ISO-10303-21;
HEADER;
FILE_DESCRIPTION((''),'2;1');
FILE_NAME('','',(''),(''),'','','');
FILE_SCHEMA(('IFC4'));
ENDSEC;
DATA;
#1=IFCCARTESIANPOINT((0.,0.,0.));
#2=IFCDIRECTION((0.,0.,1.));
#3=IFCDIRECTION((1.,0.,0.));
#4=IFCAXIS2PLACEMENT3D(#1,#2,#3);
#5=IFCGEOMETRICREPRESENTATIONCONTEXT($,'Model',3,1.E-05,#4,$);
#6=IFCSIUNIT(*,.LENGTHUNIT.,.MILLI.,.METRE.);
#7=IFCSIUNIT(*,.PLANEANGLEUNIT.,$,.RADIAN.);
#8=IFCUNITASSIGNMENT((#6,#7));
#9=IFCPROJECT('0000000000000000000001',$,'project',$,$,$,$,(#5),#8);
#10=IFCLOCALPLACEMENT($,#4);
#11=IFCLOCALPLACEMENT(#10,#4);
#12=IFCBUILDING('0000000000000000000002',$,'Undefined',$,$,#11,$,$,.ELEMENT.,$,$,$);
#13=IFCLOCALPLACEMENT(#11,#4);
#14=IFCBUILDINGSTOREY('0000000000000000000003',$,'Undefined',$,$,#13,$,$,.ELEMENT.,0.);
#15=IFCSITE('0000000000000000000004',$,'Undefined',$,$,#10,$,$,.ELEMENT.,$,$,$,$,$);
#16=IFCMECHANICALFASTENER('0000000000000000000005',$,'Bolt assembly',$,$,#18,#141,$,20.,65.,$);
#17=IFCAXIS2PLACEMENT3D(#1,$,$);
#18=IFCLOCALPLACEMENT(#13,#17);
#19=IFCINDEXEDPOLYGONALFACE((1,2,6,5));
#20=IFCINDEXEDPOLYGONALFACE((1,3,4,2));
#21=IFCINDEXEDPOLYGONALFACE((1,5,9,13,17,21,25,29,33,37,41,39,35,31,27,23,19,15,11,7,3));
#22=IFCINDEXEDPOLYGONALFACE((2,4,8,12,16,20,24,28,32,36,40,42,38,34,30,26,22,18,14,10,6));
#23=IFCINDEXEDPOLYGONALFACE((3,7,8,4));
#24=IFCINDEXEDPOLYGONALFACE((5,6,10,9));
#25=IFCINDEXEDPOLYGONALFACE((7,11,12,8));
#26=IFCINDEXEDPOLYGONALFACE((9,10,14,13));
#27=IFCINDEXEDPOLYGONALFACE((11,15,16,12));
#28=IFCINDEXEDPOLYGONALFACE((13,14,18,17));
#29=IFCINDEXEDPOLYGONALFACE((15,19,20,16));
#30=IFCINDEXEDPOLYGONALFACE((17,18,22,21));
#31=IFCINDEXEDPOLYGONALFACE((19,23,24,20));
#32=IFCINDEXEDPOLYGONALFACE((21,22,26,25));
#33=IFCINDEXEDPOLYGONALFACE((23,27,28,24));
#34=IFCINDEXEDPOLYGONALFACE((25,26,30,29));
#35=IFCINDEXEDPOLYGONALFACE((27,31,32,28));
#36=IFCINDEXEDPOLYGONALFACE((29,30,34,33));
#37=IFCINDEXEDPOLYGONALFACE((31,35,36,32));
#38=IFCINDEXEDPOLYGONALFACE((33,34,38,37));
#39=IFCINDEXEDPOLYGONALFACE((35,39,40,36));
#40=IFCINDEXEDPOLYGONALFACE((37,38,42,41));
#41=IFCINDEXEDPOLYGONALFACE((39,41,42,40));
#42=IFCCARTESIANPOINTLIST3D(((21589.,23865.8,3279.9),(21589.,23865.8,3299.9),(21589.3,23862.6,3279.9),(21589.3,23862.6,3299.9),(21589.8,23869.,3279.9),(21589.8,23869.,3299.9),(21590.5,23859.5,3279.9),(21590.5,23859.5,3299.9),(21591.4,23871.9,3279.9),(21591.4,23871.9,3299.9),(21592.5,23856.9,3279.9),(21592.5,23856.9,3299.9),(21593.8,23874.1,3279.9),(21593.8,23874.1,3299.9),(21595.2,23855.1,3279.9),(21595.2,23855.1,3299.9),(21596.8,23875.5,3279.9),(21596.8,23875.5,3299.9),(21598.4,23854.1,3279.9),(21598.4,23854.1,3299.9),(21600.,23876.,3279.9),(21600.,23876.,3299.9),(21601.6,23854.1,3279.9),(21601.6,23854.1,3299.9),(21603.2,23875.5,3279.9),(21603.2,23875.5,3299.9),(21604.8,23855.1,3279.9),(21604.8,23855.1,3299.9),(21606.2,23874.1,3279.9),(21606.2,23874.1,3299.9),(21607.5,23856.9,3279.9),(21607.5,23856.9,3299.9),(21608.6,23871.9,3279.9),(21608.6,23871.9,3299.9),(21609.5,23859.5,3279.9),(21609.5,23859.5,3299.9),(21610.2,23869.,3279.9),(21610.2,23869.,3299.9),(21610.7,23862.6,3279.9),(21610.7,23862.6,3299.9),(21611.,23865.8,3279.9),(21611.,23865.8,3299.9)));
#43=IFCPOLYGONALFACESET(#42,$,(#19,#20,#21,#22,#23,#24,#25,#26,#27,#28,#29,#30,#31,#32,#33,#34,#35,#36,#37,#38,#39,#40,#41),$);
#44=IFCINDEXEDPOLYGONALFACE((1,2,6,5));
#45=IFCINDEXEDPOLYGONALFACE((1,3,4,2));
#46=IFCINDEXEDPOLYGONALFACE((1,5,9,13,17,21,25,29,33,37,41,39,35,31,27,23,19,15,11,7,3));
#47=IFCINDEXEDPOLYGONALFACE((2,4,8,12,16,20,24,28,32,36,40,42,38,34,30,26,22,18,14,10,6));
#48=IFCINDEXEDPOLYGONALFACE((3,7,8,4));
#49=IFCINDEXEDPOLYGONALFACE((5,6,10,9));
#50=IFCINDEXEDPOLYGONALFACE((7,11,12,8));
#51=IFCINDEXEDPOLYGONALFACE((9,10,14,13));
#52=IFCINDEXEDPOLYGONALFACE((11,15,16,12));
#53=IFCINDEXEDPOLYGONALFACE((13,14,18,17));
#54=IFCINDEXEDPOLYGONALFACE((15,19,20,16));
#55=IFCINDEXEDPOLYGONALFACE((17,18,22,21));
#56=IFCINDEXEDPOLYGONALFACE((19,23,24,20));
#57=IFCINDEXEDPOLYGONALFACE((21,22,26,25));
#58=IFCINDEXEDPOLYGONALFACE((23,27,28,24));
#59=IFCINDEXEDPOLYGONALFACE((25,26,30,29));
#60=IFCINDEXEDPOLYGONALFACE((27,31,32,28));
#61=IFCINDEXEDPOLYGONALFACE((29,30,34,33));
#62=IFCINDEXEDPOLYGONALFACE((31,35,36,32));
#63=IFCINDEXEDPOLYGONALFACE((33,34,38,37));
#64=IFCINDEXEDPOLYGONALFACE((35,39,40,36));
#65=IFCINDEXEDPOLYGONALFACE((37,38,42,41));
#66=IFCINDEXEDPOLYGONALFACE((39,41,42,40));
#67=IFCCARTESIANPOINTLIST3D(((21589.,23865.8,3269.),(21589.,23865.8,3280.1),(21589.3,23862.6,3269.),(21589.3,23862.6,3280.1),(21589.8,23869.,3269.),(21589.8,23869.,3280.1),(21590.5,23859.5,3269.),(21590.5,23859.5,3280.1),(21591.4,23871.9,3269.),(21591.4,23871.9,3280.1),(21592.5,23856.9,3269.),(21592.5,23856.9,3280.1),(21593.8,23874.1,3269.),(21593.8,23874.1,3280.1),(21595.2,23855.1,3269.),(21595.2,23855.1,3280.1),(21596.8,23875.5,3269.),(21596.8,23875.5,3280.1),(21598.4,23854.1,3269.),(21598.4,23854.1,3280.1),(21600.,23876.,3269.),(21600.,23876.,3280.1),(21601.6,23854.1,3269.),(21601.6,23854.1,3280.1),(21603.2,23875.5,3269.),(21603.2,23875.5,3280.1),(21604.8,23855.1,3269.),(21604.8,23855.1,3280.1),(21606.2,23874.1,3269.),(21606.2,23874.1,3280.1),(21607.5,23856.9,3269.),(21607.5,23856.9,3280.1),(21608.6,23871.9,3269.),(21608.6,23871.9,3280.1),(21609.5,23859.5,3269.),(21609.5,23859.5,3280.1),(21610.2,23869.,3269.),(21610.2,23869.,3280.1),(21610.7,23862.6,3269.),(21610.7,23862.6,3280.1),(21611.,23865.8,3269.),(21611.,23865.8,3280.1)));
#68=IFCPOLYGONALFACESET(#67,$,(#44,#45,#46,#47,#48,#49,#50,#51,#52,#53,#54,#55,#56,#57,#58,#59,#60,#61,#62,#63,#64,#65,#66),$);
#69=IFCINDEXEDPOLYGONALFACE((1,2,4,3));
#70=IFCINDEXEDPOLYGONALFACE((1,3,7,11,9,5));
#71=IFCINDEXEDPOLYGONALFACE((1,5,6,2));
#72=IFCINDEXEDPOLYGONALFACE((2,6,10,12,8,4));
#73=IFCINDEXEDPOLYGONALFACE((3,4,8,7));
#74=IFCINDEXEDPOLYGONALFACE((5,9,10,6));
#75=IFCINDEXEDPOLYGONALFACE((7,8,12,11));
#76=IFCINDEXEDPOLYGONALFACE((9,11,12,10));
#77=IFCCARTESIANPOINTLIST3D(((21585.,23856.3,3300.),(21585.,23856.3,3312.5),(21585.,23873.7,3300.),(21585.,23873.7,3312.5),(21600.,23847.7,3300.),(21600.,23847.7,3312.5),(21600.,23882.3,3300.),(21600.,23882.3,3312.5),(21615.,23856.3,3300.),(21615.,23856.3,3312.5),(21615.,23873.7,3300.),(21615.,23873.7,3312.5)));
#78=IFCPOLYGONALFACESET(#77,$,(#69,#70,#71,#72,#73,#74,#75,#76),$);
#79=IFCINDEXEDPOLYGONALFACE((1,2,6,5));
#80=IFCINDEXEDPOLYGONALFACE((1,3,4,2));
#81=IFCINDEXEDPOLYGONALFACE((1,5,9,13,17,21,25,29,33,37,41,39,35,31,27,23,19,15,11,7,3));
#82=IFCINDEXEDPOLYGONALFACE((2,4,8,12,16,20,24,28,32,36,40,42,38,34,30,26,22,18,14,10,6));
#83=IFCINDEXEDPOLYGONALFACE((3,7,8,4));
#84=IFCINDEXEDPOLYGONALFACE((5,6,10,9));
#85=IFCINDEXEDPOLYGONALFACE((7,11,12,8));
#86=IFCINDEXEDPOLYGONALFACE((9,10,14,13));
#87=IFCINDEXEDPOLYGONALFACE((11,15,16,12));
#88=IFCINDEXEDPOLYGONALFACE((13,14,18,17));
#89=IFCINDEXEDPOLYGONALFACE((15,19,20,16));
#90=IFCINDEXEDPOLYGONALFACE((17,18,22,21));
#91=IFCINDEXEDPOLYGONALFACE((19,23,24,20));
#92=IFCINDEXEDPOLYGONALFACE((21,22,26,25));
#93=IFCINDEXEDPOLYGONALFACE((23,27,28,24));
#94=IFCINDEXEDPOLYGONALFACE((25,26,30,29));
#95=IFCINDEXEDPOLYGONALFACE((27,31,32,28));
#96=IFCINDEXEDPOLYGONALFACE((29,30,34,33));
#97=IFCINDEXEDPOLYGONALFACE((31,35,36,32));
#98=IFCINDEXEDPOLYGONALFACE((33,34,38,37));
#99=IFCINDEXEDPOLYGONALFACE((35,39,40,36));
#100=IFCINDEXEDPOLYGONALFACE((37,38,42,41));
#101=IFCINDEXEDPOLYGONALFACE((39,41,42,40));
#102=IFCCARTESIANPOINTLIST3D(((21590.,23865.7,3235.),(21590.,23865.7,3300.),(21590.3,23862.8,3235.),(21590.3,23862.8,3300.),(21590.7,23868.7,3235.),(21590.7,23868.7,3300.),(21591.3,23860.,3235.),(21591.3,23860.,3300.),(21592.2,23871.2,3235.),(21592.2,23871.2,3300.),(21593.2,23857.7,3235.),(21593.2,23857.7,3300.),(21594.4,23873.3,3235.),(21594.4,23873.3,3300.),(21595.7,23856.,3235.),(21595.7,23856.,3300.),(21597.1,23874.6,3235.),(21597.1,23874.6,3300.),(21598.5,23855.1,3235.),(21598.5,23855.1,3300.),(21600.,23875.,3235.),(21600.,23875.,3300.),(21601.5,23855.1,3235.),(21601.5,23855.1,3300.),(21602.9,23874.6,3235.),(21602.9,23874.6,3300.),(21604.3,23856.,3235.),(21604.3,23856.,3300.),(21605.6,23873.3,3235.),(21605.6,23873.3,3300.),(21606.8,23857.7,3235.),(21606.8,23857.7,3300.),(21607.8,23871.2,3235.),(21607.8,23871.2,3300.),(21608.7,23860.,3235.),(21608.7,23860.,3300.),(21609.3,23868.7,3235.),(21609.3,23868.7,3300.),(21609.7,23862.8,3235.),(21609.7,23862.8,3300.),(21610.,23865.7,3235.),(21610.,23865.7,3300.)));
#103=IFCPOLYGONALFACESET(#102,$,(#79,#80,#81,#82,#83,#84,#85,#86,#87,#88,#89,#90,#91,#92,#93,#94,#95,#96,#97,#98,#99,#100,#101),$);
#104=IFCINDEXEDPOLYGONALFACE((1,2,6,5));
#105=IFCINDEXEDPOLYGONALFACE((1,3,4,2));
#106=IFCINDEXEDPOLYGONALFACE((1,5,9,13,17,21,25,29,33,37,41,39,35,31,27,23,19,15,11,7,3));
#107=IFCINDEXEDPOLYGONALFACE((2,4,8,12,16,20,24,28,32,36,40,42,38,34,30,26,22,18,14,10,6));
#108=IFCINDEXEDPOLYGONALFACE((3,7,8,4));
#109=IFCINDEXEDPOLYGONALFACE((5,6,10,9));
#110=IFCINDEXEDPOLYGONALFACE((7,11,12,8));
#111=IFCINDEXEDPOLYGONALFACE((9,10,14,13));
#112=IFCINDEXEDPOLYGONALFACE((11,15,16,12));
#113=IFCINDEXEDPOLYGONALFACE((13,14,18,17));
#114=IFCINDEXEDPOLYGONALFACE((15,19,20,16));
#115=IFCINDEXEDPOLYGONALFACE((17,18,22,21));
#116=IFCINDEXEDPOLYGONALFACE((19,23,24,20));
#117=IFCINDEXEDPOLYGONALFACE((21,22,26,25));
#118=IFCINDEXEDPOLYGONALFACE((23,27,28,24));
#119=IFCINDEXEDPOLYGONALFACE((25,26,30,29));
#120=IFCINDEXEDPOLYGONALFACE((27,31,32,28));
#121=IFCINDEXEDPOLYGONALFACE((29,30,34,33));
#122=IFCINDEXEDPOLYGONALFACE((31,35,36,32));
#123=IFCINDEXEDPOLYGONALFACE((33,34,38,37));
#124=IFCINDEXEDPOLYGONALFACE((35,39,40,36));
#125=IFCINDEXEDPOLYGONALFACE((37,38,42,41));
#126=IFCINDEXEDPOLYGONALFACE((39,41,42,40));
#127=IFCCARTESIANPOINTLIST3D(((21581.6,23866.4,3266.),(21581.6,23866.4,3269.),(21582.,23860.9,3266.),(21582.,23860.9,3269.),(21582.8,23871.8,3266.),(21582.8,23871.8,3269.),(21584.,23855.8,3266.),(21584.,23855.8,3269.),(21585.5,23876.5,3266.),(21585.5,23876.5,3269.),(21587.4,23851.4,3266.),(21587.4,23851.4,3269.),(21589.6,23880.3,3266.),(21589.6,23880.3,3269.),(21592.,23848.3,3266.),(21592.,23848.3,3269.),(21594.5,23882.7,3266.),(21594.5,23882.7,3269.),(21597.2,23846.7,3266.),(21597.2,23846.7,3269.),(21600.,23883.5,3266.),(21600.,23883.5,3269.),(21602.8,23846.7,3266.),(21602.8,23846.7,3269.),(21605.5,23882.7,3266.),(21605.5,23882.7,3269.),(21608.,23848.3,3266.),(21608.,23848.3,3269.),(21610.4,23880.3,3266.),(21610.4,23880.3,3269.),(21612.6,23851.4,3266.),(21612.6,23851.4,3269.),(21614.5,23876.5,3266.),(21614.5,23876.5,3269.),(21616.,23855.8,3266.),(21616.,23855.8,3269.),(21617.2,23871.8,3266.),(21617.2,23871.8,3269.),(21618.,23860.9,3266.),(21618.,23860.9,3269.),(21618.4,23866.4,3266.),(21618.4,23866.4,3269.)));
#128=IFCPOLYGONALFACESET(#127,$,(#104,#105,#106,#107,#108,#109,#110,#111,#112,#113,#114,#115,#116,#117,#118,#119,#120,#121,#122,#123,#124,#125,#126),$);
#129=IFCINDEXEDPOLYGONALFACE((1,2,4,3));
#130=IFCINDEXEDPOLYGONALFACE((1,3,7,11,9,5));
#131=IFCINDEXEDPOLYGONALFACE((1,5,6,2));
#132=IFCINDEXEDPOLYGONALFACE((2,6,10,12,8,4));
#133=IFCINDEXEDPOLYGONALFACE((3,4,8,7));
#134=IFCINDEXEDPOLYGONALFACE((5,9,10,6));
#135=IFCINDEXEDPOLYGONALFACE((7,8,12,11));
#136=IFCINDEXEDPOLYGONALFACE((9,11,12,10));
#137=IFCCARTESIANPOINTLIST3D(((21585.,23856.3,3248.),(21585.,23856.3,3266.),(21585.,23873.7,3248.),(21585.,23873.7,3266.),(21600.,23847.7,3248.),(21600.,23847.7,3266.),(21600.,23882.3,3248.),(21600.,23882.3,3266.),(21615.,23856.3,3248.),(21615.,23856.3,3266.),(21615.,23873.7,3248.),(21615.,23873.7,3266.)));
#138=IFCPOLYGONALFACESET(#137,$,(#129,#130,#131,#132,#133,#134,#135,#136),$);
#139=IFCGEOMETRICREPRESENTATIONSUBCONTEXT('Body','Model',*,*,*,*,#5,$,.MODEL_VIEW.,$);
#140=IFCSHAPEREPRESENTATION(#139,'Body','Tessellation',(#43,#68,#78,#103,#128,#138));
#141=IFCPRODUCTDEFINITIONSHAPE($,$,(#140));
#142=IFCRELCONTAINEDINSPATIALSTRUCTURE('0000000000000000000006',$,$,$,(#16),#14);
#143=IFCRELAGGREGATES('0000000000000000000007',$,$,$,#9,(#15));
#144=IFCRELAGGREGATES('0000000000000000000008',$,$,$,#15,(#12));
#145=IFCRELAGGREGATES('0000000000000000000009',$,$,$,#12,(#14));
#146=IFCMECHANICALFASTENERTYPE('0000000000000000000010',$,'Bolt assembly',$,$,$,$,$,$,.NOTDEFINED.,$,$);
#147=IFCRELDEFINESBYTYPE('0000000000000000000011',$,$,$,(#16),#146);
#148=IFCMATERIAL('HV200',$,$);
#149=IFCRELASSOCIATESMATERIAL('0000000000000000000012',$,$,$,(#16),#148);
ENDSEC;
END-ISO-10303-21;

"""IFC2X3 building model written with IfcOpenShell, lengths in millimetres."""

from ifc_helpers import new_model, si_unit, frame, origin_with_axes, origin_2d_with_axis, place, context, subcontext, project, spatial, polyline, circle, outline, extrude, source, transform, mapped, material, type_object, element, save


model = new_model("IFC2X3")

# Units and contexts
model_context = context("Model", 3, precision=1e-05, world=origin_with_axes())
body_context = subcontext(model_context, "Body", "Model", "MODEL_VIEW")
ifc_project = project(units=[si_unit("LENGTHUNIT", "METRE", prefix="MILLI"), si_unit("PLANEANGLEUNIT", "RADIAN")], contexts=[model_context])

# Site, building, storey
site_placement = place(None, origin_with_axes())
site = spatial("IfcSite", under=ifc_project, at=site_placement, Name="Undefined", CompositionType="ELEMENT")
building_placement = place(site_placement, origin_with_axes())
building = spatial("IfcBuilding", under=site, at=building_placement, Name="Undefined", CompositionType="ELEMENT")
storey_placement = place(building_placement, origin_with_axes())
storey = spatial("IfcBuildingStorey", under=building, at=storey_placement, Name="Undefined", CompositionType="ELEMENT", Elevation=0.0)

# Mechanical fastener
ifc_material_1 = material(Name="HV200")
mechanical_fastener_type = type_object("IfcMechanicalFastenerType", Name="Bolt assembly")
shared_shape_1 = source(origin_with_axes(), body_context, "Body", "SweptSolid", [
    extrude(circle(Radius=11.0, at=origin_2d_with_axis()), frame((0.0, -19.9, 0.0), z_axis=(0.0, 1.0, 0.0), x_axis=(1.0, 0.0, 0.0)), (0.0, 0.0, 1.0), 20.0),
    extrude(circle(Radius=11.0, at=origin_2d_with_axis()), frame((0.0, -0.1, 0.0), z_axis=(0.0, 1.0, 0.0), x_axis=(1.0, 0.0, 0.0)), (0.0, 0.0, 1.0), 11.1),
    extrude(outline(polyline([(17.3, 0.0), (8.7, 15.0), (-8.7, 15.0), (-17.3, 0.0), (-8.7, -15.0), (8.7, -15.0), (17.3, 0.0)])), frame((0.0, -32.5, 0.0), z_axis=(0.0, 1.0, 0.0), x_axis=(1.0, 0.0, 0.0)), (0.0, 0.0, 1.0), 12.5),
    extrude(circle(Radius=10.0, at=origin_2d_with_axis()), frame((0.0, -20.0, 0.0), z_axis=(0.0, 1.0, 0.0), x_axis=(1.0, 0.0, 0.0)), (0.0, 0.0, 1.0), 65.0),
    extrude(circle(Radius=18.5, at=origin_2d_with_axis()), frame((0.0, 11.0, 0.0), z_axis=(0.0, 1.0, 0.0), x_axis=(1.0, 0.0, 0.0)), (0.0, 0.0, 1.0), 3.0),
    extrude(outline(polyline([(17.3, 0.0), (8.7, 15.0), (-8.7, 15.0), (-17.3, 0.0), (-8.7, -15.0), (8.7, -15.0), (17.3, 0.0)])), frame((0.0, 14.0, 0.0), z_axis=(0.0, 1.0, 0.0), x_axis=(1.0, 0.0, 0.0)), (0.0, 0.0, 1.0), 18.0),
])
for number, where, z_axis, x_axis, name in (
    (1, (21600.0, 23865.0, 3280.0), (-1.0, 0.0, 0.0), (0.0, 1.0, 0.0), "Bolt assembly"),
):
    element("IfcMechanicalFastener", number, at=place(storey_placement, frame(where, z_axis=z_axis, x_axis=x_axis)), inside=storey, type_object=mechanical_fastener_type, material=ifc_material_1, Name=name, NominalDiameter=20.0, NominalLength=65.0, context=body_context, shape_type="MappedRepresentation", body=[
        mapped(shared_shape_1, transform((0.0, 0.0, 0.0))),
    ])

save(model, "model.ifc")
